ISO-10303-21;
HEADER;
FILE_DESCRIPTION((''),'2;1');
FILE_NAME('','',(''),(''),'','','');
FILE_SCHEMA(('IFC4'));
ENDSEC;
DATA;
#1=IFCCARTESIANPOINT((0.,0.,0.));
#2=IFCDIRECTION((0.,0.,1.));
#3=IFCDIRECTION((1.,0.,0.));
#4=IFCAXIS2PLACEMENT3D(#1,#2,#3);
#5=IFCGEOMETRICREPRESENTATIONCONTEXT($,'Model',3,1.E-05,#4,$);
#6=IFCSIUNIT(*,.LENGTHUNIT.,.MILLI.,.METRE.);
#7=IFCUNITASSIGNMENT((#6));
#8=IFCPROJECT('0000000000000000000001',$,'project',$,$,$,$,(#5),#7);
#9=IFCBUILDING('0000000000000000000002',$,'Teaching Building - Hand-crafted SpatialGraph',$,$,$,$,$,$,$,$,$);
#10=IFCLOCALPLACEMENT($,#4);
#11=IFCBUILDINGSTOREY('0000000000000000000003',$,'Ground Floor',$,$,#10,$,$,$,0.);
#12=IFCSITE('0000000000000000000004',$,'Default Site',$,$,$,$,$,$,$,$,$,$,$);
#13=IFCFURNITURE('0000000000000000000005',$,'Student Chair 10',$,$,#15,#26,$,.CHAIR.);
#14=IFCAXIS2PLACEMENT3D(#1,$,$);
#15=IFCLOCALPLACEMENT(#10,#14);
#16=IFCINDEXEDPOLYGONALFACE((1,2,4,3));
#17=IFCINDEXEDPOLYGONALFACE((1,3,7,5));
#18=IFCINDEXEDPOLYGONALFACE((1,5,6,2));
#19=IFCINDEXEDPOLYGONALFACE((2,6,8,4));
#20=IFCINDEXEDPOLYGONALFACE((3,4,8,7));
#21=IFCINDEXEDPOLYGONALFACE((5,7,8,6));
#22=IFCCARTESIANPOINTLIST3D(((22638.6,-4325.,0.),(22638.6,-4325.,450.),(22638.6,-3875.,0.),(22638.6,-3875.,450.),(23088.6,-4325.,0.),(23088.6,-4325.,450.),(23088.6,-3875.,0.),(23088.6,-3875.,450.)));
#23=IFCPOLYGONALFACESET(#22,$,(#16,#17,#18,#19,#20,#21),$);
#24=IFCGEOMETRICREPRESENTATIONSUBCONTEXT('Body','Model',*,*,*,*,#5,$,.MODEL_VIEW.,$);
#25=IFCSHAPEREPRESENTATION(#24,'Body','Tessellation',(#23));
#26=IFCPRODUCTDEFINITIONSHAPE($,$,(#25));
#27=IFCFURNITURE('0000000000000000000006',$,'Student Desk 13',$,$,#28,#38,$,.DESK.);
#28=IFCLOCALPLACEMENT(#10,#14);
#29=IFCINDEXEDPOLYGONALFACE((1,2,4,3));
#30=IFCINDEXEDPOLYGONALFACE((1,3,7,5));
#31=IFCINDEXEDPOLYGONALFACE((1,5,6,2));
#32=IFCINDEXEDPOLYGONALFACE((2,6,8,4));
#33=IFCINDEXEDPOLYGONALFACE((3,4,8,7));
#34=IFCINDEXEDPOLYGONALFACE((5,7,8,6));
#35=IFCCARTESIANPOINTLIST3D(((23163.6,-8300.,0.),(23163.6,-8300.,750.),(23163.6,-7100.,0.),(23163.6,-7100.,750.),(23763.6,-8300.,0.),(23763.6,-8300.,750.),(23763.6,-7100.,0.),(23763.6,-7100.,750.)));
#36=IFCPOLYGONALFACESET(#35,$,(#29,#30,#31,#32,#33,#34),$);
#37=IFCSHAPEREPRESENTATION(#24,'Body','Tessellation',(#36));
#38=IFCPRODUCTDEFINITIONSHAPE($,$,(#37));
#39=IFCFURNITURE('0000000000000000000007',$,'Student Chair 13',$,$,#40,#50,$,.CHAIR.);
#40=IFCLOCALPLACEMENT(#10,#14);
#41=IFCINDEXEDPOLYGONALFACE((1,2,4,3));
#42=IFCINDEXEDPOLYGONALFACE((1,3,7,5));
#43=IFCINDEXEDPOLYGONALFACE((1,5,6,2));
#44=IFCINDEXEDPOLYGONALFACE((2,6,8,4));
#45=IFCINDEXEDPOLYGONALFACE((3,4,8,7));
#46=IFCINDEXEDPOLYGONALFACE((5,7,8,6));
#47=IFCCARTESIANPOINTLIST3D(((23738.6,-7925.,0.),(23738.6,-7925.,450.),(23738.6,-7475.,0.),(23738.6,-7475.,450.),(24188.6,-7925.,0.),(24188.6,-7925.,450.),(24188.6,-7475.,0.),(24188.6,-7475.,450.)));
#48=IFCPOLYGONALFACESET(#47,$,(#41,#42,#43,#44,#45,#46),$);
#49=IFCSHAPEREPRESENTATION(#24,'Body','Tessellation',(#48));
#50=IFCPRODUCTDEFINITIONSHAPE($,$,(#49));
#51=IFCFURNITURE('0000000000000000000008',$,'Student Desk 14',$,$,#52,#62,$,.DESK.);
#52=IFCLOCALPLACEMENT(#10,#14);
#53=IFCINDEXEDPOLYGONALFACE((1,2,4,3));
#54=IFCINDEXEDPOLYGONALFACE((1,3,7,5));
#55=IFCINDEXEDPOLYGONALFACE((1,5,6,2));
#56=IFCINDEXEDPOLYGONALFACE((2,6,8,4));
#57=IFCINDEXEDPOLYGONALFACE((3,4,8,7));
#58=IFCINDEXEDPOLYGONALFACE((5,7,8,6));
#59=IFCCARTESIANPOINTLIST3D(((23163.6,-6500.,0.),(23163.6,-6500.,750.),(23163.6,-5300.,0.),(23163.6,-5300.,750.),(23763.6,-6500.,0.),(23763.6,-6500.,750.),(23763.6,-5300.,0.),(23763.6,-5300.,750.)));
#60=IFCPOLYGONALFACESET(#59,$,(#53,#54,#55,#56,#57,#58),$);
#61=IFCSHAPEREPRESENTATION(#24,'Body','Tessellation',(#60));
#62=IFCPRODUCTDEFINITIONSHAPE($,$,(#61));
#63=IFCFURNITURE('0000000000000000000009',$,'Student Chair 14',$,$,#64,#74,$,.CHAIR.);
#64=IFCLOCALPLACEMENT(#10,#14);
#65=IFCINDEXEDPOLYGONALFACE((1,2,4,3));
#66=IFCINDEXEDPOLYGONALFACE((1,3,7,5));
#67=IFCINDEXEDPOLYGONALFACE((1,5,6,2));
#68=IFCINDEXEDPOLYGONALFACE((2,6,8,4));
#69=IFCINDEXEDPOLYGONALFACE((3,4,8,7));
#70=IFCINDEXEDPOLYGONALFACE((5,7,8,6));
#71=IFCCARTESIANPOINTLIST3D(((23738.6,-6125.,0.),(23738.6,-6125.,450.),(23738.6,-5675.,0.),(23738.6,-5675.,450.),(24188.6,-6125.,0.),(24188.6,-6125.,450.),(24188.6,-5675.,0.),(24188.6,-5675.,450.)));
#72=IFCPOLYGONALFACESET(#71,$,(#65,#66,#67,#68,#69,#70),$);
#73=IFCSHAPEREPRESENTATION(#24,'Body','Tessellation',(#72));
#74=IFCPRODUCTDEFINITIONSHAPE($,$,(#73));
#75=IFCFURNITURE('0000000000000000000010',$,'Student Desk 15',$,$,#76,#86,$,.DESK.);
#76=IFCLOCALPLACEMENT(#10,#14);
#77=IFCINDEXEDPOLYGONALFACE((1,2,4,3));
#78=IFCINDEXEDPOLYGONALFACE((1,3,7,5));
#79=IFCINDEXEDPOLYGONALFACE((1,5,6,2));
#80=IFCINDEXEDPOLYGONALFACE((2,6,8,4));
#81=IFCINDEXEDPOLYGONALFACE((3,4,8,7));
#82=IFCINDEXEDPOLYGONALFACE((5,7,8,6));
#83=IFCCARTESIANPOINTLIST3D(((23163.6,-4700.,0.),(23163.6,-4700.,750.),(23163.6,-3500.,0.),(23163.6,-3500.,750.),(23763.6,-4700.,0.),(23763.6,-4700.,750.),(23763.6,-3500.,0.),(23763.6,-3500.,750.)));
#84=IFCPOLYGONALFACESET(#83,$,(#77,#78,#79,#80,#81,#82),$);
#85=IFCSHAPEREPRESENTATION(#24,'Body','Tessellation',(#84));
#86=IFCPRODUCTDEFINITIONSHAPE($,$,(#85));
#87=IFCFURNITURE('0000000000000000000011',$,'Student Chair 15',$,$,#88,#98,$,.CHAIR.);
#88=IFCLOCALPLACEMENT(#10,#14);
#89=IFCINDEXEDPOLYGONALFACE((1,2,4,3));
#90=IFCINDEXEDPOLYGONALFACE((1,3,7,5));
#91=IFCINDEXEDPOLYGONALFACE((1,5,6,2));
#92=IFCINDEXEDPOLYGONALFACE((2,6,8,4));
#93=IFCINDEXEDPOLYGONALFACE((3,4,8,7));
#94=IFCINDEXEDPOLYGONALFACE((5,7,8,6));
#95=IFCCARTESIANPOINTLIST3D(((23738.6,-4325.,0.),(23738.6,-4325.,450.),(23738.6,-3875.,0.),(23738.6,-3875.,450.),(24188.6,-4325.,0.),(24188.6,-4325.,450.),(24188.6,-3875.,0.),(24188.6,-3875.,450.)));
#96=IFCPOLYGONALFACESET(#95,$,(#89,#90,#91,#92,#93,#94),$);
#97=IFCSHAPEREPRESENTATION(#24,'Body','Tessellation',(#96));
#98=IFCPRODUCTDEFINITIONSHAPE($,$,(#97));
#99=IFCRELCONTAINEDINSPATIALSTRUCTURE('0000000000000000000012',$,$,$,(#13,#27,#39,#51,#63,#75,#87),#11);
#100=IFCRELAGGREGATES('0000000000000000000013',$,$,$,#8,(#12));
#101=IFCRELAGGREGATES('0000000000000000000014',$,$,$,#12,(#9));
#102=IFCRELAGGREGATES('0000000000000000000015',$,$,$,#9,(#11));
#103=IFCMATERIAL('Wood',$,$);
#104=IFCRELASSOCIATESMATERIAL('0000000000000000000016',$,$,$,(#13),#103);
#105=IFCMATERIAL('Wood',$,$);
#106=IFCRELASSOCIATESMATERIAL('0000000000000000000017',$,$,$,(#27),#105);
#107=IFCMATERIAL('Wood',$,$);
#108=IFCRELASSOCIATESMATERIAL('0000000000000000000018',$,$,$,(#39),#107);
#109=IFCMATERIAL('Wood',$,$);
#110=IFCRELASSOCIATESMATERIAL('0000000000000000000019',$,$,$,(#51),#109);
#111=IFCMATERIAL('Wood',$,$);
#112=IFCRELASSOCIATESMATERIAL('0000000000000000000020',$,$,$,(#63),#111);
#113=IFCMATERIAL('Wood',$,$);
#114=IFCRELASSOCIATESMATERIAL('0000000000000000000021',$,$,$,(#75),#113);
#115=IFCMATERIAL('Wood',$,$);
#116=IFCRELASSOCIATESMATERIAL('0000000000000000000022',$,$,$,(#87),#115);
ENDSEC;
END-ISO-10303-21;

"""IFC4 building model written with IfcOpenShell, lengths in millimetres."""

from ifc_helpers import new_model, si_unit, frame, origin_with_axes, origin_2d, place, context, subcontext, project, spatial, rectangle, extrude, material, element, save


model = new_model("IFC4")

# Units and contexts
model_context = context("Model", 3, precision=1e-05, world=origin_with_axes())
body_context = subcontext(model_context, "Body", "Model", "MODEL_VIEW")
ifc_project = project(units=[si_unit("LENGTHUNIT", "METRE", prefix="MILLI")], contexts=[model_context])

# Site, building, storey
site = spatial("IfcSite", under=ifc_project, Name="Default Site")
building = spatial("IfcBuilding", under=site, Name="Teaching Building - Hand-crafted SpatialGraph")
storey_placement = place(None, origin_with_axes())
storey = spatial("IfcBuildingStorey", under=building, at=storey_placement, Name="Ground Floor", Elevation=0.0)

# Furniture
ifc_material_1 = material(Name="Wood")
furniture_1_placement = place(storey_placement, frame((22863.6, -4100.0, 0.0), z_axis=(0.0, 0.0, 1.0), x_axis=(1.0, 0.0, 0.0)))
element("IfcFurniture", 1, at=furniture_1_placement, inside=storey, material=ifc_material_1, Name="Student Chair 10", PredefinedType="CHAIR", context=body_context, shape_type="SweptSolid", body=[
    extrude(rectangle(XDim=450.0, YDim=450.0, at=origin_2d()), origin_with_axes(), (0.0, 0.0, 1.0), 450.0),
])
ifc_material_2 = material(Name="Wood")
furniture_2_placement = place(storey_placement, frame((23463.6, -7700.0, 0.0), z_axis=(0.0, 0.0, 1.0), x_axis=(0.0, 1.0, 0.0)))
element("IfcFurniture", 2, at=furniture_2_placement, inside=storey, material=ifc_material_2, Name="Student Desk 13", PredefinedType="DESK", context=body_context, shape_type="SweptSolid", body=[
    extrude(rectangle(XDim=1200.0, YDim=600.0, at=origin_2d()), origin_with_axes(), (0.0, 0.0, 1.0), 750.0),
])
ifc_material_3 = material(Name="Wood")
furniture_3_placement = place(storey_placement, frame((23963.6, -7700.0, 0.0), z_axis=(0.0, 0.0, 1.0), x_axis=(1.0, 0.0, 0.0)))
element("IfcFurniture", 3, at=furniture_3_placement, inside=storey, material=ifc_material_3, Name="Student Chair 13", PredefinedType="CHAIR", context=body_context, shape_type="SweptSolid", body=[
    extrude(rectangle(XDim=450.0, YDim=450.0, at=origin_2d()), origin_with_axes(), (0.0, 0.0, 1.0), 450.0),
])
ifc_material_4 = material(Name="Wood")
furniture_4_placement = place(storey_placement, frame((23463.6, -5900.0, 0.0), z_axis=(0.0, 0.0, 1.0), x_axis=(0.0, 1.0, 0.0)))
element("IfcFurniture", 4, at=furniture_4_placement, inside=storey, material=ifc_material_4, Name="Student Desk 14", PredefinedType="DESK", context=body_context, shape_type="SweptSolid", body=[
    extrude(rectangle(XDim=1200.0, YDim=600.0, at=origin_2d()), origin_with_axes(), (0.0, 0.0, 1.0), 750.0),
])
ifc_material_5 = material(Name="Wood")
furniture_5_placement = place(storey_placement, frame((23963.6, -5900.0, 0.0), z_axis=(0.0, 0.0, 1.0), x_axis=(1.0, 0.0, 0.0)))
element("IfcFurniture", 5, at=furniture_5_placement, inside=storey, material=ifc_material_5, Name="Student Chair 14", PredefinedType="CHAIR", context=body_context, shape_type="SweptSolid", body=[
    extrude(rectangle(XDim=450.0, YDim=450.0, at=origin_2d()), origin_with_axes(), (0.0, 0.0, 1.0), 450.0),
])
ifc_material_6 = material(Name="Wood")
furniture_6_placement = place(storey_placement, frame((23463.6, -4100.0, 0.0), z_axis=(0.0, 0.0, 1.0), x_axis=(0.0, 1.0, 0.0)))
element("IfcFurniture", 6, at=furniture_6_placement, inside=storey, material=ifc_material_6, Name="Student Desk 15", PredefinedType="DESK", context=body_context, shape_type="SweptSolid", body=[
    extrude(rectangle(XDim=1200.0, YDim=600.0, at=origin_2d()), origin_with_axes(), (0.0, 0.0, 1.0), 750.0),
])
ifc_material_7 = material(Name="Wood")
furniture_7_placement = place(storey_placement, frame((23963.6, -4100.0, 0.0), z_axis=(0.0, 0.0, 1.0), x_axis=(1.0, 0.0, 0.0)))
element("IfcFurniture", 7, at=furniture_7_placement, inside=storey, material=ifc_material_7, Name="Student Chair 15", PredefinedType="CHAIR", context=body_context, shape_type="SweptSolid", body=[
    extrude(rectangle(XDim=450.0, YDim=450.0, at=origin_2d()), origin_with_axes(), (0.0, 0.0, 1.0), 450.0),
])

save(model, "model.ifc")
